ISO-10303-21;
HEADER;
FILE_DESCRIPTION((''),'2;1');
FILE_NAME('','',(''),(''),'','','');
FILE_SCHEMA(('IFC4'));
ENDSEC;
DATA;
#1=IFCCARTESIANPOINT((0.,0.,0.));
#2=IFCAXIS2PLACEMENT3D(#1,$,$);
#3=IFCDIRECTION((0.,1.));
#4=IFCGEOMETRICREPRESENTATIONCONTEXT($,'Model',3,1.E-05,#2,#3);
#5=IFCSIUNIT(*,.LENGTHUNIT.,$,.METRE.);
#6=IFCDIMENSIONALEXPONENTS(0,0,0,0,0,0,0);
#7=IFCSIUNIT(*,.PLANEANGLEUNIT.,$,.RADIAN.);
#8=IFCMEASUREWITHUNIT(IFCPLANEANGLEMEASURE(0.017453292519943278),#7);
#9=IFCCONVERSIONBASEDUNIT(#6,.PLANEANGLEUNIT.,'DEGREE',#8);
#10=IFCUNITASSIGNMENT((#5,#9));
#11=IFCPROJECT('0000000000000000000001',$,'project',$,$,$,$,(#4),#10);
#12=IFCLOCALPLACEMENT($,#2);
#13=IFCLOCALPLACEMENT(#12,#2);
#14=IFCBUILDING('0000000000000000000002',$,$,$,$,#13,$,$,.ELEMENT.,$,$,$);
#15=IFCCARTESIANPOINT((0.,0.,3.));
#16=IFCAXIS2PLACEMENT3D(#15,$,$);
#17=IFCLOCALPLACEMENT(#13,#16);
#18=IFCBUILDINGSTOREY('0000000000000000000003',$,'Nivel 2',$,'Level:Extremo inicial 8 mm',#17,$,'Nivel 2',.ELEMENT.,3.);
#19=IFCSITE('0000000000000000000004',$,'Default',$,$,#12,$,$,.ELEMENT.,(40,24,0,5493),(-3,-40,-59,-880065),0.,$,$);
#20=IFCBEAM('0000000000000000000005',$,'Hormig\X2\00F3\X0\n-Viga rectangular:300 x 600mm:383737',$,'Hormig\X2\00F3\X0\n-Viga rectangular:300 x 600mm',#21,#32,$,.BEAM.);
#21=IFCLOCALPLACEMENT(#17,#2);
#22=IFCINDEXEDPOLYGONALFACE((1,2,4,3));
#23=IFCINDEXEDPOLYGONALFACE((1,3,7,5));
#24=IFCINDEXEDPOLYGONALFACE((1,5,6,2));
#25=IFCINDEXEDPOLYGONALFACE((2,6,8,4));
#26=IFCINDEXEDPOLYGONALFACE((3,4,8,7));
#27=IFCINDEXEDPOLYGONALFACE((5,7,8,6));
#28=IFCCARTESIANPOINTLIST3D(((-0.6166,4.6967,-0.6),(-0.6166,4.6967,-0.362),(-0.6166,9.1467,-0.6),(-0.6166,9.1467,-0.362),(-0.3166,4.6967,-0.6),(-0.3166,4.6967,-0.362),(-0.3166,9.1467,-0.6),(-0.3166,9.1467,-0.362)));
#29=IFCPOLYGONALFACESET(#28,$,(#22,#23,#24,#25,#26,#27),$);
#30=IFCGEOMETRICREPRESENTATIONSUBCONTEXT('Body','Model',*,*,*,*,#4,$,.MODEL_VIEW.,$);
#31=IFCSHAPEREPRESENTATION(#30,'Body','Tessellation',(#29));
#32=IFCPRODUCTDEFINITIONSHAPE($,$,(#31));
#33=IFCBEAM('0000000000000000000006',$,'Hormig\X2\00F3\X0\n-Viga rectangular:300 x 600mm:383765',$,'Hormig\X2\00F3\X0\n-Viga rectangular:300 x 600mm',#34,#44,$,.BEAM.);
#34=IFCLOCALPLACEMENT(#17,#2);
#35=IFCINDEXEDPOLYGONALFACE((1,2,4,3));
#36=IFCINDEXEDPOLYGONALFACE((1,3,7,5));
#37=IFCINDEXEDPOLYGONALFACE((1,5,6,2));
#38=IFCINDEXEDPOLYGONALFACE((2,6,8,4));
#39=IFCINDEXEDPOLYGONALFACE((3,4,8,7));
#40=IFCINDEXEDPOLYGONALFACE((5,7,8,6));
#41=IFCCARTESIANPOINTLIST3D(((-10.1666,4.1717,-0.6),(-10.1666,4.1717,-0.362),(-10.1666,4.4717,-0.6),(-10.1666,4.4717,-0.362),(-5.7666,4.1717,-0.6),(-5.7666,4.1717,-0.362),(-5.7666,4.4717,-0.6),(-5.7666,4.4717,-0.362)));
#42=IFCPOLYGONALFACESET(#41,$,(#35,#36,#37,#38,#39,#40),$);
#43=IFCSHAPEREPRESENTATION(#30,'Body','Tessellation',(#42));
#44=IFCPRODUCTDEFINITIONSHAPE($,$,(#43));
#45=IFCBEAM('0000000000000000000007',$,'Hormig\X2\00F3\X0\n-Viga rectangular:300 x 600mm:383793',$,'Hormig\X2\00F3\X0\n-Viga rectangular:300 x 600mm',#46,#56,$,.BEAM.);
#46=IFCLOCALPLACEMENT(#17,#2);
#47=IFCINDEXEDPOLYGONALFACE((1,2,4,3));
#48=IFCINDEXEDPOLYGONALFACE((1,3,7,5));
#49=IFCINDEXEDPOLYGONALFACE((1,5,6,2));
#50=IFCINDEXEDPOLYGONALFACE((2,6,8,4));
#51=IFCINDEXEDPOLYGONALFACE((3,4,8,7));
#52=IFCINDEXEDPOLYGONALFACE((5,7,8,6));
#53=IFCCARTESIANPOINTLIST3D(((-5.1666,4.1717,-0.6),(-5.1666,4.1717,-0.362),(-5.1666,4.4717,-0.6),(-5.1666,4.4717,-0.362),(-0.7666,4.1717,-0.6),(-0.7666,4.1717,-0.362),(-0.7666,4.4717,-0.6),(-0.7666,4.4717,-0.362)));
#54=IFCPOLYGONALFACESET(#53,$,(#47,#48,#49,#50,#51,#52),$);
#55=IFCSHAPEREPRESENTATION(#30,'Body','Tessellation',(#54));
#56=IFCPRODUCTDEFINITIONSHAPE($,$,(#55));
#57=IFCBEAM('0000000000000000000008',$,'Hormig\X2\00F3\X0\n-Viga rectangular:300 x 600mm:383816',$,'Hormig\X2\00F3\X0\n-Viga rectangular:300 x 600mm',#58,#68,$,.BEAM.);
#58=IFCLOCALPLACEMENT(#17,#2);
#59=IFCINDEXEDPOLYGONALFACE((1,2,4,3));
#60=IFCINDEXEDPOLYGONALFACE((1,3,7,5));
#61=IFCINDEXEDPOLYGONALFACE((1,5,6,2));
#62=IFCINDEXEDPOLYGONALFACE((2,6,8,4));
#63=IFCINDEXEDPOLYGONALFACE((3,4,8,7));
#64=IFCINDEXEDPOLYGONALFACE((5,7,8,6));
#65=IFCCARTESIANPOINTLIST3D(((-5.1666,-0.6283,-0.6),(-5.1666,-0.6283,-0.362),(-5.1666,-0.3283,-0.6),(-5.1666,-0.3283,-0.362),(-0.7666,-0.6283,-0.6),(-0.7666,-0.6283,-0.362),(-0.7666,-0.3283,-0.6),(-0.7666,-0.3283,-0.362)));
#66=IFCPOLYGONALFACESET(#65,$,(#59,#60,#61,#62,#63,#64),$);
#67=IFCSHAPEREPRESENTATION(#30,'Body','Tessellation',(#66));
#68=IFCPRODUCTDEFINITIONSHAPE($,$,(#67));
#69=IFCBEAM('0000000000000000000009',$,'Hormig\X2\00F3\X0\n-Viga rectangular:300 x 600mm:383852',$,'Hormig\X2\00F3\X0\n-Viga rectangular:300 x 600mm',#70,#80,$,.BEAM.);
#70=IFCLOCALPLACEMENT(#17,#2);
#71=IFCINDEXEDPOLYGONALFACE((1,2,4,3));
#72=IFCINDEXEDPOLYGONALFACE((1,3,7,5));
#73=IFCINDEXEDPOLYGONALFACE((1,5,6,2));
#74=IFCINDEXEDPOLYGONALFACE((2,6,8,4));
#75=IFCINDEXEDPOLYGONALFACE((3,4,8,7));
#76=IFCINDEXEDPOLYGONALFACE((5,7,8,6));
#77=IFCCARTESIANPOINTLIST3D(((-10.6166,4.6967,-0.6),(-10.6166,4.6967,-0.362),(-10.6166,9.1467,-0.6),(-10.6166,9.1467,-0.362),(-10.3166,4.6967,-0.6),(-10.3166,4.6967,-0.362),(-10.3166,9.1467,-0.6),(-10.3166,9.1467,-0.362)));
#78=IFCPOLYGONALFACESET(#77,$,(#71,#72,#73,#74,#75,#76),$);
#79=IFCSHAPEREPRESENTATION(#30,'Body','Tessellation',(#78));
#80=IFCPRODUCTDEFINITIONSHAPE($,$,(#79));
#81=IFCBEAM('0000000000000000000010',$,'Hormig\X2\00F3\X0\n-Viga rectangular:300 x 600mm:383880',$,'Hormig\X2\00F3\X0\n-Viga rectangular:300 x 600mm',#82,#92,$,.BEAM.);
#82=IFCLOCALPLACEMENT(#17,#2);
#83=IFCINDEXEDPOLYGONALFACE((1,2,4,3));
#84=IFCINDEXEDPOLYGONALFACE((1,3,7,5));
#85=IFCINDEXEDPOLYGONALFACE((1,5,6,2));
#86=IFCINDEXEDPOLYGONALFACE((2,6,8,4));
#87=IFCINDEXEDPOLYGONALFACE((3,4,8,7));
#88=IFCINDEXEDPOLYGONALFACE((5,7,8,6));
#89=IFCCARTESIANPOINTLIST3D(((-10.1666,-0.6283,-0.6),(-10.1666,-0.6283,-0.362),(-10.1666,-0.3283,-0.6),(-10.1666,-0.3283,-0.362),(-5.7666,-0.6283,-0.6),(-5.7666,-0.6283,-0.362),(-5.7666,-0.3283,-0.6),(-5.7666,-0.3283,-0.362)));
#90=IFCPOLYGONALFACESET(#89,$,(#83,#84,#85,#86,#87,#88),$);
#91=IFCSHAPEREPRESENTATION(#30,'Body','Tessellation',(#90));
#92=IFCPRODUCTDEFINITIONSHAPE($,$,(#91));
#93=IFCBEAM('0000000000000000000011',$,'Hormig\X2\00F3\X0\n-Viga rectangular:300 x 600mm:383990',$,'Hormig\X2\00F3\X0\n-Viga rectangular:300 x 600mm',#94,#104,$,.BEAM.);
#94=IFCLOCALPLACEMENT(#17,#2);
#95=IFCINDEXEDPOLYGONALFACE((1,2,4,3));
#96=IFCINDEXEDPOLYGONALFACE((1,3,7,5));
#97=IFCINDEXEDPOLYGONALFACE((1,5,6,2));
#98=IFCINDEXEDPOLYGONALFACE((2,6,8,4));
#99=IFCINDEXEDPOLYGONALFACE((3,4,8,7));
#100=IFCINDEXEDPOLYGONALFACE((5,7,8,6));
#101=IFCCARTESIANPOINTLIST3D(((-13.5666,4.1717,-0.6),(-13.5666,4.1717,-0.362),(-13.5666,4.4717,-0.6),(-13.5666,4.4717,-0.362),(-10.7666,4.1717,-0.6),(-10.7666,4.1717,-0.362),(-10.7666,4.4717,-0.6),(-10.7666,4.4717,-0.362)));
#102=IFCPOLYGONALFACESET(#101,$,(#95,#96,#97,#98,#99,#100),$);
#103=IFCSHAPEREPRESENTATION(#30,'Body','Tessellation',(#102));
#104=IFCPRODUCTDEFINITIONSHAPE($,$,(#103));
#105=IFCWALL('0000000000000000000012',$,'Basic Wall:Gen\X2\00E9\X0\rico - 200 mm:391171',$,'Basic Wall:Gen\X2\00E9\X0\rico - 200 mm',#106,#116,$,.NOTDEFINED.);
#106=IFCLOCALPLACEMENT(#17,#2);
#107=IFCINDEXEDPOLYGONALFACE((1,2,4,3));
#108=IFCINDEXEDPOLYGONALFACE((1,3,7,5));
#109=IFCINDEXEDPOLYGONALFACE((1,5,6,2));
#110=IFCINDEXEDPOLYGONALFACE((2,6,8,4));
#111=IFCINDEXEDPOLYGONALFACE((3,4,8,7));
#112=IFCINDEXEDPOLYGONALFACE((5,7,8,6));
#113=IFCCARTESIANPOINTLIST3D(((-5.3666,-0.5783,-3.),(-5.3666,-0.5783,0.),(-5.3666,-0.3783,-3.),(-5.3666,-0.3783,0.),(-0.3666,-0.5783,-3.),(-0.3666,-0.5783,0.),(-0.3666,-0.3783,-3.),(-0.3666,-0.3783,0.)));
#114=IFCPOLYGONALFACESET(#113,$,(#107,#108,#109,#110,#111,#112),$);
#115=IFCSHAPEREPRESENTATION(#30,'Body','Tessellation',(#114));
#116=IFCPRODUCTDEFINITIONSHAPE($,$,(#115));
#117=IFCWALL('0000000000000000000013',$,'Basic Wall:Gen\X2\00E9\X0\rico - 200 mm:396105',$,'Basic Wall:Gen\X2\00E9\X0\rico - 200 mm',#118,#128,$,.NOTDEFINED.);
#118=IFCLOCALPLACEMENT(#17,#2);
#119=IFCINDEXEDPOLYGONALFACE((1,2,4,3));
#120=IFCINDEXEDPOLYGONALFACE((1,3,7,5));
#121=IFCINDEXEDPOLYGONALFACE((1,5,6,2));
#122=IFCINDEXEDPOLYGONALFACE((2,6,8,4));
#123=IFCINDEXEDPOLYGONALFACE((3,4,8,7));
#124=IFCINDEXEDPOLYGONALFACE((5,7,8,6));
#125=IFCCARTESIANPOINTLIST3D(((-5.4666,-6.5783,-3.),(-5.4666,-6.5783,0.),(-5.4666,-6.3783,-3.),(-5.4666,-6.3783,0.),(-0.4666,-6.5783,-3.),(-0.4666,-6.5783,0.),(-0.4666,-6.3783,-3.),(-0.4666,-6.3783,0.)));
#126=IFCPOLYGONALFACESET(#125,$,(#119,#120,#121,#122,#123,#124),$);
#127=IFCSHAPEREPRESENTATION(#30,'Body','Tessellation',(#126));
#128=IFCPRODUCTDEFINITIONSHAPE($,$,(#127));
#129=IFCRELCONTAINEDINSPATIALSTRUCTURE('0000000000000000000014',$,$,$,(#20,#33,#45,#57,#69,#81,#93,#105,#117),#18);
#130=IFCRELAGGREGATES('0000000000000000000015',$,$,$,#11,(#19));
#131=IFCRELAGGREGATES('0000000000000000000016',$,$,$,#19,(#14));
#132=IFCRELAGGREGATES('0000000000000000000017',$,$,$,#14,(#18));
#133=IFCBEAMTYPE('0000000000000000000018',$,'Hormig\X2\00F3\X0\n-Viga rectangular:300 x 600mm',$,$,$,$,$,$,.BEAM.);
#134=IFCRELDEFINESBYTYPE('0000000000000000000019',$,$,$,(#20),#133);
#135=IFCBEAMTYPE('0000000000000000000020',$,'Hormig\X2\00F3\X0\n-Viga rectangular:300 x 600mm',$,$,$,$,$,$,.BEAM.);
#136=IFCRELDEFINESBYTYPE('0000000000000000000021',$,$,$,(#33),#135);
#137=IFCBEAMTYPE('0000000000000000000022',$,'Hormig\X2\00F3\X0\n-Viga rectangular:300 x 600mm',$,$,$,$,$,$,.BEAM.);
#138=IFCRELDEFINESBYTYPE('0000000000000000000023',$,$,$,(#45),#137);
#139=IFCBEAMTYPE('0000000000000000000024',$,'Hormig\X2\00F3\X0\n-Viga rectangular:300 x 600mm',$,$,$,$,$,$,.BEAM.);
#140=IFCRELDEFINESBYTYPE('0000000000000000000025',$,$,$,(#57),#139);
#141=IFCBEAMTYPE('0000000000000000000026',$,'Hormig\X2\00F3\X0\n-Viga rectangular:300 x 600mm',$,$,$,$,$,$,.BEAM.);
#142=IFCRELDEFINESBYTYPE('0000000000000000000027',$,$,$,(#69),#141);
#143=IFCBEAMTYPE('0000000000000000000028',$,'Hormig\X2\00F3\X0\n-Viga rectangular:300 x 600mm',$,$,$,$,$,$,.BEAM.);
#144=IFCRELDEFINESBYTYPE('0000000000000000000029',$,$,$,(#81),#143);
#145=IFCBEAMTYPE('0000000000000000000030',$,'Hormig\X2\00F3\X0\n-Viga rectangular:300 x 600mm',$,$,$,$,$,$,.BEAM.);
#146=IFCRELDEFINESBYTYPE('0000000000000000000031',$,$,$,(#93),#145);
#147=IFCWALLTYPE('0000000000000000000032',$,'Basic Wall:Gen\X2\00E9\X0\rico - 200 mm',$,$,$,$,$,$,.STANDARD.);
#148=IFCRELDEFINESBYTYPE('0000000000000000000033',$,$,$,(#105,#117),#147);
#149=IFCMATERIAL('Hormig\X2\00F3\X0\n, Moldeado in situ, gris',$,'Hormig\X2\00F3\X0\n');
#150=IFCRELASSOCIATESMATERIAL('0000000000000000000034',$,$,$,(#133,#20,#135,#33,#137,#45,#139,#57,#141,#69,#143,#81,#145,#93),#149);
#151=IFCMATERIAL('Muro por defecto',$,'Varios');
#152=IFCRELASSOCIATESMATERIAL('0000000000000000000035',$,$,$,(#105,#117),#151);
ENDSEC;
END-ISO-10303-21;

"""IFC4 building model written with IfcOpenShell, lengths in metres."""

from ifc_helpers import new_model, entity, si_unit, converted_unit, direction, frame, origin, place, context, subcontext, project, spatial, indexed_curve, outline, extrude, source, transform, mapped, material, type_object, type_shapes, element, save


model = new_model("IFC4")

# Units and contexts
model_context = context("Model", 3, precision=1e-05, world=origin(), true_north=direction((0.0, 1.0)))
body_context = subcontext(model_context, "Body", "Model", "MODEL_VIEW")
ifc_project = project(units=[si_unit("LENGTHUNIT", "METRE"), converted_unit("PLANEANGLEUNIT", "DEGREE", entity("IfcPlaneAngleMeasure", 0.017453292519943278), si_unit("PLANEANGLEUNIT", "RADIAN"), dimensions=[0, 0, 0, 0, 0, 0, 0])], contexts=[model_context])

# Site, building, storey
site_placement = place(None, origin())
site = spatial("IfcSite", under=ifc_project, at=site_placement, Name="Default", CompositionType="ELEMENT", RefLatitude=(40, 24, 0, 5493), RefLongitude=(-3, -40, -59, -880065), RefElevation=0.0)
building_placement = place(site_placement, origin())
building = spatial("IfcBuilding", under=site, at=building_placement, CompositionType="ELEMENT")
storey_placement = place(building_placement, frame((0.0, 0.0, 3.0)))
storey = spatial("IfcBuildingStorey", under=building, at=storey_placement, Name="Nivel 2", ObjectType="Level:Extremo inicial 8 mm", LongName="Nivel 2", CompositionType="ELEMENT", Elevation=3.0)

# Beams
ifc_material_1 = material(Name="Hormigón, Moldeado in situ, gris", Category="Hormigón")
beam_type_1 = type_object("IfcBeamType", Name="Hormigón-Viga rectangular:300 x 600mm", PredefinedType="BEAM", material=ifc_material_1)
shared_shape_1 = source(origin(), body_context, "Body", "SweptSolid", [
    extrude(outline(indexed_curve([(-0.15, -0.119), (0.15, -0.119), (0.15, 0.119), (-0.15, 0.119), (-0.15, -0.119)], self_intersect=False)), frame((-0.4666, 9.1467, 2.519), z_axis=(0.0, -1.0, 0.0), x_axis=(-1.0, 0.0, 0.0)), (0.0, 0.0, 1.0), 4.45),
])
type_shapes(beam_type_1, [shared_shape_1])
beam_1_placement = place(storey_placement, frame((0.0, 0.0, -3.0)))
element("IfcBeam", 1, at=beam_1_placement, inside=storey, type_object=beam_type_1, material=ifc_material_1, Name="Hormigón-Viga rectangular:300 x 600mm:383737", ObjectType="Hormigón-Viga rectangular:300 x 600mm", PredefinedType="BEAM", context=body_context, shape_type="MappedRepresentation", body=[
    mapped(shared_shape_1, transform((0.0, 0.0, 0.0), scale=1.0)),
])
beam_type_2 = type_object("IfcBeamType", Name="Hormigón-Viga rectangular:300 x 600mm", PredefinedType="BEAM", material=ifc_material_1)
shared_shape_2 = source(origin(), body_context, "Body", "SweptSolid", [
    extrude(outline(indexed_curve([(-0.119, -0.15), (0.119, -0.15), (0.119, 0.15), (-0.119, 0.15), (-0.119, -0.15)], self_intersect=False)), frame((-10.1666, 4.3217, 2.519), z_axis=(1.0, 0.0, 0.0), x_axis=(0.0, 0.0, -1.0)), (0.0, 0.0, 1.0), 4.4),
])
type_shapes(beam_type_2, [shared_shape_2])
beam_2_placement = place(storey_placement, frame((0.0, 0.0, -3.0)))
element("IfcBeam", 2, at=beam_2_placement, inside=storey, type_object=beam_type_2, material=ifc_material_1, Name="Hormigón-Viga rectangular:300 x 600mm:383765", ObjectType="Hormigón-Viga rectangular:300 x 600mm", PredefinedType="BEAM", context=body_context, shape_type="MappedRepresentation", body=[
    mapped(shared_shape_2, transform((0.0, 0.0, 0.0), scale=1.0)),
])
beam_type_3 = type_object("IfcBeamType", Name="Hormigón-Viga rectangular:300 x 600mm", PredefinedType="BEAM", material=ifc_material_1)
shared_shape_3 = source(origin(), body_context, "Body", "SweptSolid", [
    extrude(outline(indexed_curve([(-0.119, -0.15), (0.119, -0.15), (0.119, 0.15), (-0.119, 0.15), (-0.119, -0.15)], self_intersect=False)), frame((-5.1666, 4.3217, 2.519), z_axis=(1.0, 0.0, 0.0), x_axis=(0.0, 0.0, -1.0)), (0.0, 0.0, 1.0), 4.4),
])
type_shapes(beam_type_3, [shared_shape_3])
beam_3_placement = place(storey_placement, frame((0.0, 0.0, -3.0)))
element("IfcBeam", 3, at=beam_3_placement, inside=storey, type_object=beam_type_3, material=ifc_material_1, Name="Hormigón-Viga rectangular:300 x 600mm:383793", ObjectType="Hormigón-Viga rectangular:300 x 600mm", PredefinedType="BEAM", context=body_context, shape_type="MappedRepresentation", body=[
    mapped(shared_shape_3, transform((0.0, 0.0, 0.0), scale=1.0)),
])
beam_type_4 = type_object("IfcBeamType", Name="Hormigón-Viga rectangular:300 x 600mm", PredefinedType="BEAM", material=ifc_material_1)
shared_shape_4 = source(origin(), body_context, "Body", "SweptSolid", [
    extrude(outline(indexed_curve([(-0.119, -0.15), (0.119, -0.15), (0.119, 0.15), (-0.119, 0.15), (-0.119, -0.15)], self_intersect=False)), frame((-0.7666, -0.4783, 2.519), z_axis=(-1.0, 0.0, 0.0), x_axis=(0.0, 0.0, -1.0)), (0.0, 0.0, 1.0), 4.4),
])
type_shapes(beam_type_4, [shared_shape_4])
beam_4_placement = place(storey_placement, frame((0.0, 0.0, -3.0)))
element("IfcBeam", 4, at=beam_4_placement, inside=storey, type_object=beam_type_4, material=ifc_material_1, Name="Hormigón-Viga rectangular:300 x 600mm:383816", ObjectType="Hormigón-Viga rectangular:300 x 600mm", PredefinedType="BEAM", context=body_context, shape_type="MappedRepresentation", body=[
    mapped(shared_shape_4, transform((0.0, 0.0, 0.0), scale=1.0)),
])
beam_type_5 = type_object("IfcBeamType", Name="Hormigón-Viga rectangular:300 x 600mm", PredefinedType="BEAM", material=ifc_material_1)
shared_shape_5 = source(origin(), body_context, "Body", "SweptSolid", [
    extrude(outline(indexed_curve([(-0.15, -0.119), (0.15, -0.119), (0.15, 0.119), (-0.15, 0.119), (-0.15, -0.119)], self_intersect=False)), frame((-10.4666, 4.6967, 2.519), z_axis=(0.0, 1.0, 0.0), x_axis=(-1.0, 0.0, 0.0)), (0.0, 0.0, 1.0), 4.45),
])
type_shapes(beam_type_5, [shared_shape_5])
beam_5_placement = place(storey_placement, frame((0.0, 0.0, -3.0)))
element("IfcBeam", 5, at=beam_5_placement, inside=storey, type_object=beam_type_5, material=ifc_material_1, Name="Hormigón-Viga rectangular:300 x 600mm:383852", ObjectType="Hormigón-Viga rectangular:300 x 600mm", PredefinedType="BEAM", context=body_context, shape_type="MappedRepresentation", body=[
    mapped(shared_shape_5, transform((0.0, 0.0, 0.0), scale=1.0)),
])
beam_type_6 = type_object("IfcBeamType", Name="Hormigón-Viga rectangular:300 x 600mm", PredefinedType="BEAM", material=ifc_material_1)
shared_shape_6 = source(origin(), body_context, "Body", "SweptSolid", [
    extrude(outline(indexed_curve([(-0.119, -0.15), (0.119, -0.15), (0.119, 0.15), (-0.119, 0.15), (-0.119, -0.15)], self_intersect=False)), frame((-10.1666, -0.4783, 2.519), z_axis=(1.0, 0.0, 0.0), x_axis=(0.0, 0.0, -1.0)), (0.0, 0.0, 1.0), 4.4),
])
type_shapes(beam_type_6, [shared_shape_6])
beam_6_placement = place(storey_placement, frame((0.0, 0.0, -3.0)))
element("IfcBeam", 6, at=beam_6_placement, inside=storey, type_object=beam_type_6, material=ifc_material_1, Name="Hormigón-Viga rectangular:300 x 600mm:383880", ObjectType="Hormigón-Viga rectangular:300 x 600mm", PredefinedType="BEAM", context=body_context, shape_type="MappedRepresentation", body=[
    mapped(shared_shape_6, transform((0.0, 0.0, 0.0), scale=1.0)),
])
beam_type_7 = type_object("IfcBeamType", Name="Hormigón-Viga rectangular:300 x 600mm", PredefinedType="BEAM", material=ifc_material_1)
shared_shape_7 = source(origin(), body_context, "Body", "SweptSolid", [
    extrude(outline(indexed_curve([(-0.119, -0.15), (0.119, -0.15), (0.119, 0.15), (-0.119, 0.15), (-0.119, -0.15)], self_intersect=False)), frame((-10.7666, 4.3217, 2.519), z_axis=(-1.0, 0.0, 0.0), x_axis=(0.0, 0.0, -1.0)), (0.0, 0.0, 1.0), 2.8),
])
type_shapes(beam_type_7, [shared_shape_7])
beam_7_placement = place(storey_placement, frame((0.0, 0.0, -3.0)))
element("IfcBeam", 7, at=beam_7_placement, inside=storey, type_object=beam_type_7, material=ifc_material_1, Name="Hormigón-Viga rectangular:300 x 600mm:383990", ObjectType="Hormigón-Viga rectangular:300 x 600mm", PredefinedType="BEAM", context=body_context, shape_type="MappedRepresentation", body=[
    mapped(shared_shape_7, transform((0.0, 0.0, 0.0), scale=1.0)),
])

# Walls
ifc_material_2 = material(Name="Muro por defecto", Category="Varios")
wall_type = type_object("IfcWallType", Name="Basic Wall:Genérico - 200 mm", PredefinedType="STANDARD")
wall_1_placement = place(storey_placement, frame((-5.3666, -0.4783, -3.0)))
element("IfcWall", 8, at=wall_1_placement, inside=storey, type_object=wall_type, material=ifc_material_2, Name="Basic Wall:Genérico - 200 mm:391171", ObjectType="Basic Wall:Genérico - 200 mm", PredefinedType="NOTDEFINED", context=body_context, shape_type="SweptSolid", body=[
    extrude(outline(indexed_curve([(5.0, 0.1), (0.0, 0.1), (0.0, -0.1), (5.0, -0.1), (5.0, 0.1)], self_intersect=False)), origin(), (0.0, 0.0, 1.0), 3.0),
])
wall_2_placement = place(storey_placement, frame((-5.4666, -6.4783, -3.0)))
element("IfcWall", 9, at=wall_2_placement, inside=storey, type_object=wall_type, material=ifc_material_2, Name="Basic Wall:Genérico - 200 mm:396105", ObjectType="Basic Wall:Genérico - 200 mm", PredefinedType="NOTDEFINED", context=body_context, shape_type="SweptSolid", body=[
    extrude(outline(indexed_curve([(5.0, 0.1), (0.0, 0.1), (0.0, -0.1), (5.0, -0.1), (5.0, 0.1)], self_intersect=False)), origin(), (0.0, 0.0, 1.0), 3.0),
])

save(model, "model.ifc")
